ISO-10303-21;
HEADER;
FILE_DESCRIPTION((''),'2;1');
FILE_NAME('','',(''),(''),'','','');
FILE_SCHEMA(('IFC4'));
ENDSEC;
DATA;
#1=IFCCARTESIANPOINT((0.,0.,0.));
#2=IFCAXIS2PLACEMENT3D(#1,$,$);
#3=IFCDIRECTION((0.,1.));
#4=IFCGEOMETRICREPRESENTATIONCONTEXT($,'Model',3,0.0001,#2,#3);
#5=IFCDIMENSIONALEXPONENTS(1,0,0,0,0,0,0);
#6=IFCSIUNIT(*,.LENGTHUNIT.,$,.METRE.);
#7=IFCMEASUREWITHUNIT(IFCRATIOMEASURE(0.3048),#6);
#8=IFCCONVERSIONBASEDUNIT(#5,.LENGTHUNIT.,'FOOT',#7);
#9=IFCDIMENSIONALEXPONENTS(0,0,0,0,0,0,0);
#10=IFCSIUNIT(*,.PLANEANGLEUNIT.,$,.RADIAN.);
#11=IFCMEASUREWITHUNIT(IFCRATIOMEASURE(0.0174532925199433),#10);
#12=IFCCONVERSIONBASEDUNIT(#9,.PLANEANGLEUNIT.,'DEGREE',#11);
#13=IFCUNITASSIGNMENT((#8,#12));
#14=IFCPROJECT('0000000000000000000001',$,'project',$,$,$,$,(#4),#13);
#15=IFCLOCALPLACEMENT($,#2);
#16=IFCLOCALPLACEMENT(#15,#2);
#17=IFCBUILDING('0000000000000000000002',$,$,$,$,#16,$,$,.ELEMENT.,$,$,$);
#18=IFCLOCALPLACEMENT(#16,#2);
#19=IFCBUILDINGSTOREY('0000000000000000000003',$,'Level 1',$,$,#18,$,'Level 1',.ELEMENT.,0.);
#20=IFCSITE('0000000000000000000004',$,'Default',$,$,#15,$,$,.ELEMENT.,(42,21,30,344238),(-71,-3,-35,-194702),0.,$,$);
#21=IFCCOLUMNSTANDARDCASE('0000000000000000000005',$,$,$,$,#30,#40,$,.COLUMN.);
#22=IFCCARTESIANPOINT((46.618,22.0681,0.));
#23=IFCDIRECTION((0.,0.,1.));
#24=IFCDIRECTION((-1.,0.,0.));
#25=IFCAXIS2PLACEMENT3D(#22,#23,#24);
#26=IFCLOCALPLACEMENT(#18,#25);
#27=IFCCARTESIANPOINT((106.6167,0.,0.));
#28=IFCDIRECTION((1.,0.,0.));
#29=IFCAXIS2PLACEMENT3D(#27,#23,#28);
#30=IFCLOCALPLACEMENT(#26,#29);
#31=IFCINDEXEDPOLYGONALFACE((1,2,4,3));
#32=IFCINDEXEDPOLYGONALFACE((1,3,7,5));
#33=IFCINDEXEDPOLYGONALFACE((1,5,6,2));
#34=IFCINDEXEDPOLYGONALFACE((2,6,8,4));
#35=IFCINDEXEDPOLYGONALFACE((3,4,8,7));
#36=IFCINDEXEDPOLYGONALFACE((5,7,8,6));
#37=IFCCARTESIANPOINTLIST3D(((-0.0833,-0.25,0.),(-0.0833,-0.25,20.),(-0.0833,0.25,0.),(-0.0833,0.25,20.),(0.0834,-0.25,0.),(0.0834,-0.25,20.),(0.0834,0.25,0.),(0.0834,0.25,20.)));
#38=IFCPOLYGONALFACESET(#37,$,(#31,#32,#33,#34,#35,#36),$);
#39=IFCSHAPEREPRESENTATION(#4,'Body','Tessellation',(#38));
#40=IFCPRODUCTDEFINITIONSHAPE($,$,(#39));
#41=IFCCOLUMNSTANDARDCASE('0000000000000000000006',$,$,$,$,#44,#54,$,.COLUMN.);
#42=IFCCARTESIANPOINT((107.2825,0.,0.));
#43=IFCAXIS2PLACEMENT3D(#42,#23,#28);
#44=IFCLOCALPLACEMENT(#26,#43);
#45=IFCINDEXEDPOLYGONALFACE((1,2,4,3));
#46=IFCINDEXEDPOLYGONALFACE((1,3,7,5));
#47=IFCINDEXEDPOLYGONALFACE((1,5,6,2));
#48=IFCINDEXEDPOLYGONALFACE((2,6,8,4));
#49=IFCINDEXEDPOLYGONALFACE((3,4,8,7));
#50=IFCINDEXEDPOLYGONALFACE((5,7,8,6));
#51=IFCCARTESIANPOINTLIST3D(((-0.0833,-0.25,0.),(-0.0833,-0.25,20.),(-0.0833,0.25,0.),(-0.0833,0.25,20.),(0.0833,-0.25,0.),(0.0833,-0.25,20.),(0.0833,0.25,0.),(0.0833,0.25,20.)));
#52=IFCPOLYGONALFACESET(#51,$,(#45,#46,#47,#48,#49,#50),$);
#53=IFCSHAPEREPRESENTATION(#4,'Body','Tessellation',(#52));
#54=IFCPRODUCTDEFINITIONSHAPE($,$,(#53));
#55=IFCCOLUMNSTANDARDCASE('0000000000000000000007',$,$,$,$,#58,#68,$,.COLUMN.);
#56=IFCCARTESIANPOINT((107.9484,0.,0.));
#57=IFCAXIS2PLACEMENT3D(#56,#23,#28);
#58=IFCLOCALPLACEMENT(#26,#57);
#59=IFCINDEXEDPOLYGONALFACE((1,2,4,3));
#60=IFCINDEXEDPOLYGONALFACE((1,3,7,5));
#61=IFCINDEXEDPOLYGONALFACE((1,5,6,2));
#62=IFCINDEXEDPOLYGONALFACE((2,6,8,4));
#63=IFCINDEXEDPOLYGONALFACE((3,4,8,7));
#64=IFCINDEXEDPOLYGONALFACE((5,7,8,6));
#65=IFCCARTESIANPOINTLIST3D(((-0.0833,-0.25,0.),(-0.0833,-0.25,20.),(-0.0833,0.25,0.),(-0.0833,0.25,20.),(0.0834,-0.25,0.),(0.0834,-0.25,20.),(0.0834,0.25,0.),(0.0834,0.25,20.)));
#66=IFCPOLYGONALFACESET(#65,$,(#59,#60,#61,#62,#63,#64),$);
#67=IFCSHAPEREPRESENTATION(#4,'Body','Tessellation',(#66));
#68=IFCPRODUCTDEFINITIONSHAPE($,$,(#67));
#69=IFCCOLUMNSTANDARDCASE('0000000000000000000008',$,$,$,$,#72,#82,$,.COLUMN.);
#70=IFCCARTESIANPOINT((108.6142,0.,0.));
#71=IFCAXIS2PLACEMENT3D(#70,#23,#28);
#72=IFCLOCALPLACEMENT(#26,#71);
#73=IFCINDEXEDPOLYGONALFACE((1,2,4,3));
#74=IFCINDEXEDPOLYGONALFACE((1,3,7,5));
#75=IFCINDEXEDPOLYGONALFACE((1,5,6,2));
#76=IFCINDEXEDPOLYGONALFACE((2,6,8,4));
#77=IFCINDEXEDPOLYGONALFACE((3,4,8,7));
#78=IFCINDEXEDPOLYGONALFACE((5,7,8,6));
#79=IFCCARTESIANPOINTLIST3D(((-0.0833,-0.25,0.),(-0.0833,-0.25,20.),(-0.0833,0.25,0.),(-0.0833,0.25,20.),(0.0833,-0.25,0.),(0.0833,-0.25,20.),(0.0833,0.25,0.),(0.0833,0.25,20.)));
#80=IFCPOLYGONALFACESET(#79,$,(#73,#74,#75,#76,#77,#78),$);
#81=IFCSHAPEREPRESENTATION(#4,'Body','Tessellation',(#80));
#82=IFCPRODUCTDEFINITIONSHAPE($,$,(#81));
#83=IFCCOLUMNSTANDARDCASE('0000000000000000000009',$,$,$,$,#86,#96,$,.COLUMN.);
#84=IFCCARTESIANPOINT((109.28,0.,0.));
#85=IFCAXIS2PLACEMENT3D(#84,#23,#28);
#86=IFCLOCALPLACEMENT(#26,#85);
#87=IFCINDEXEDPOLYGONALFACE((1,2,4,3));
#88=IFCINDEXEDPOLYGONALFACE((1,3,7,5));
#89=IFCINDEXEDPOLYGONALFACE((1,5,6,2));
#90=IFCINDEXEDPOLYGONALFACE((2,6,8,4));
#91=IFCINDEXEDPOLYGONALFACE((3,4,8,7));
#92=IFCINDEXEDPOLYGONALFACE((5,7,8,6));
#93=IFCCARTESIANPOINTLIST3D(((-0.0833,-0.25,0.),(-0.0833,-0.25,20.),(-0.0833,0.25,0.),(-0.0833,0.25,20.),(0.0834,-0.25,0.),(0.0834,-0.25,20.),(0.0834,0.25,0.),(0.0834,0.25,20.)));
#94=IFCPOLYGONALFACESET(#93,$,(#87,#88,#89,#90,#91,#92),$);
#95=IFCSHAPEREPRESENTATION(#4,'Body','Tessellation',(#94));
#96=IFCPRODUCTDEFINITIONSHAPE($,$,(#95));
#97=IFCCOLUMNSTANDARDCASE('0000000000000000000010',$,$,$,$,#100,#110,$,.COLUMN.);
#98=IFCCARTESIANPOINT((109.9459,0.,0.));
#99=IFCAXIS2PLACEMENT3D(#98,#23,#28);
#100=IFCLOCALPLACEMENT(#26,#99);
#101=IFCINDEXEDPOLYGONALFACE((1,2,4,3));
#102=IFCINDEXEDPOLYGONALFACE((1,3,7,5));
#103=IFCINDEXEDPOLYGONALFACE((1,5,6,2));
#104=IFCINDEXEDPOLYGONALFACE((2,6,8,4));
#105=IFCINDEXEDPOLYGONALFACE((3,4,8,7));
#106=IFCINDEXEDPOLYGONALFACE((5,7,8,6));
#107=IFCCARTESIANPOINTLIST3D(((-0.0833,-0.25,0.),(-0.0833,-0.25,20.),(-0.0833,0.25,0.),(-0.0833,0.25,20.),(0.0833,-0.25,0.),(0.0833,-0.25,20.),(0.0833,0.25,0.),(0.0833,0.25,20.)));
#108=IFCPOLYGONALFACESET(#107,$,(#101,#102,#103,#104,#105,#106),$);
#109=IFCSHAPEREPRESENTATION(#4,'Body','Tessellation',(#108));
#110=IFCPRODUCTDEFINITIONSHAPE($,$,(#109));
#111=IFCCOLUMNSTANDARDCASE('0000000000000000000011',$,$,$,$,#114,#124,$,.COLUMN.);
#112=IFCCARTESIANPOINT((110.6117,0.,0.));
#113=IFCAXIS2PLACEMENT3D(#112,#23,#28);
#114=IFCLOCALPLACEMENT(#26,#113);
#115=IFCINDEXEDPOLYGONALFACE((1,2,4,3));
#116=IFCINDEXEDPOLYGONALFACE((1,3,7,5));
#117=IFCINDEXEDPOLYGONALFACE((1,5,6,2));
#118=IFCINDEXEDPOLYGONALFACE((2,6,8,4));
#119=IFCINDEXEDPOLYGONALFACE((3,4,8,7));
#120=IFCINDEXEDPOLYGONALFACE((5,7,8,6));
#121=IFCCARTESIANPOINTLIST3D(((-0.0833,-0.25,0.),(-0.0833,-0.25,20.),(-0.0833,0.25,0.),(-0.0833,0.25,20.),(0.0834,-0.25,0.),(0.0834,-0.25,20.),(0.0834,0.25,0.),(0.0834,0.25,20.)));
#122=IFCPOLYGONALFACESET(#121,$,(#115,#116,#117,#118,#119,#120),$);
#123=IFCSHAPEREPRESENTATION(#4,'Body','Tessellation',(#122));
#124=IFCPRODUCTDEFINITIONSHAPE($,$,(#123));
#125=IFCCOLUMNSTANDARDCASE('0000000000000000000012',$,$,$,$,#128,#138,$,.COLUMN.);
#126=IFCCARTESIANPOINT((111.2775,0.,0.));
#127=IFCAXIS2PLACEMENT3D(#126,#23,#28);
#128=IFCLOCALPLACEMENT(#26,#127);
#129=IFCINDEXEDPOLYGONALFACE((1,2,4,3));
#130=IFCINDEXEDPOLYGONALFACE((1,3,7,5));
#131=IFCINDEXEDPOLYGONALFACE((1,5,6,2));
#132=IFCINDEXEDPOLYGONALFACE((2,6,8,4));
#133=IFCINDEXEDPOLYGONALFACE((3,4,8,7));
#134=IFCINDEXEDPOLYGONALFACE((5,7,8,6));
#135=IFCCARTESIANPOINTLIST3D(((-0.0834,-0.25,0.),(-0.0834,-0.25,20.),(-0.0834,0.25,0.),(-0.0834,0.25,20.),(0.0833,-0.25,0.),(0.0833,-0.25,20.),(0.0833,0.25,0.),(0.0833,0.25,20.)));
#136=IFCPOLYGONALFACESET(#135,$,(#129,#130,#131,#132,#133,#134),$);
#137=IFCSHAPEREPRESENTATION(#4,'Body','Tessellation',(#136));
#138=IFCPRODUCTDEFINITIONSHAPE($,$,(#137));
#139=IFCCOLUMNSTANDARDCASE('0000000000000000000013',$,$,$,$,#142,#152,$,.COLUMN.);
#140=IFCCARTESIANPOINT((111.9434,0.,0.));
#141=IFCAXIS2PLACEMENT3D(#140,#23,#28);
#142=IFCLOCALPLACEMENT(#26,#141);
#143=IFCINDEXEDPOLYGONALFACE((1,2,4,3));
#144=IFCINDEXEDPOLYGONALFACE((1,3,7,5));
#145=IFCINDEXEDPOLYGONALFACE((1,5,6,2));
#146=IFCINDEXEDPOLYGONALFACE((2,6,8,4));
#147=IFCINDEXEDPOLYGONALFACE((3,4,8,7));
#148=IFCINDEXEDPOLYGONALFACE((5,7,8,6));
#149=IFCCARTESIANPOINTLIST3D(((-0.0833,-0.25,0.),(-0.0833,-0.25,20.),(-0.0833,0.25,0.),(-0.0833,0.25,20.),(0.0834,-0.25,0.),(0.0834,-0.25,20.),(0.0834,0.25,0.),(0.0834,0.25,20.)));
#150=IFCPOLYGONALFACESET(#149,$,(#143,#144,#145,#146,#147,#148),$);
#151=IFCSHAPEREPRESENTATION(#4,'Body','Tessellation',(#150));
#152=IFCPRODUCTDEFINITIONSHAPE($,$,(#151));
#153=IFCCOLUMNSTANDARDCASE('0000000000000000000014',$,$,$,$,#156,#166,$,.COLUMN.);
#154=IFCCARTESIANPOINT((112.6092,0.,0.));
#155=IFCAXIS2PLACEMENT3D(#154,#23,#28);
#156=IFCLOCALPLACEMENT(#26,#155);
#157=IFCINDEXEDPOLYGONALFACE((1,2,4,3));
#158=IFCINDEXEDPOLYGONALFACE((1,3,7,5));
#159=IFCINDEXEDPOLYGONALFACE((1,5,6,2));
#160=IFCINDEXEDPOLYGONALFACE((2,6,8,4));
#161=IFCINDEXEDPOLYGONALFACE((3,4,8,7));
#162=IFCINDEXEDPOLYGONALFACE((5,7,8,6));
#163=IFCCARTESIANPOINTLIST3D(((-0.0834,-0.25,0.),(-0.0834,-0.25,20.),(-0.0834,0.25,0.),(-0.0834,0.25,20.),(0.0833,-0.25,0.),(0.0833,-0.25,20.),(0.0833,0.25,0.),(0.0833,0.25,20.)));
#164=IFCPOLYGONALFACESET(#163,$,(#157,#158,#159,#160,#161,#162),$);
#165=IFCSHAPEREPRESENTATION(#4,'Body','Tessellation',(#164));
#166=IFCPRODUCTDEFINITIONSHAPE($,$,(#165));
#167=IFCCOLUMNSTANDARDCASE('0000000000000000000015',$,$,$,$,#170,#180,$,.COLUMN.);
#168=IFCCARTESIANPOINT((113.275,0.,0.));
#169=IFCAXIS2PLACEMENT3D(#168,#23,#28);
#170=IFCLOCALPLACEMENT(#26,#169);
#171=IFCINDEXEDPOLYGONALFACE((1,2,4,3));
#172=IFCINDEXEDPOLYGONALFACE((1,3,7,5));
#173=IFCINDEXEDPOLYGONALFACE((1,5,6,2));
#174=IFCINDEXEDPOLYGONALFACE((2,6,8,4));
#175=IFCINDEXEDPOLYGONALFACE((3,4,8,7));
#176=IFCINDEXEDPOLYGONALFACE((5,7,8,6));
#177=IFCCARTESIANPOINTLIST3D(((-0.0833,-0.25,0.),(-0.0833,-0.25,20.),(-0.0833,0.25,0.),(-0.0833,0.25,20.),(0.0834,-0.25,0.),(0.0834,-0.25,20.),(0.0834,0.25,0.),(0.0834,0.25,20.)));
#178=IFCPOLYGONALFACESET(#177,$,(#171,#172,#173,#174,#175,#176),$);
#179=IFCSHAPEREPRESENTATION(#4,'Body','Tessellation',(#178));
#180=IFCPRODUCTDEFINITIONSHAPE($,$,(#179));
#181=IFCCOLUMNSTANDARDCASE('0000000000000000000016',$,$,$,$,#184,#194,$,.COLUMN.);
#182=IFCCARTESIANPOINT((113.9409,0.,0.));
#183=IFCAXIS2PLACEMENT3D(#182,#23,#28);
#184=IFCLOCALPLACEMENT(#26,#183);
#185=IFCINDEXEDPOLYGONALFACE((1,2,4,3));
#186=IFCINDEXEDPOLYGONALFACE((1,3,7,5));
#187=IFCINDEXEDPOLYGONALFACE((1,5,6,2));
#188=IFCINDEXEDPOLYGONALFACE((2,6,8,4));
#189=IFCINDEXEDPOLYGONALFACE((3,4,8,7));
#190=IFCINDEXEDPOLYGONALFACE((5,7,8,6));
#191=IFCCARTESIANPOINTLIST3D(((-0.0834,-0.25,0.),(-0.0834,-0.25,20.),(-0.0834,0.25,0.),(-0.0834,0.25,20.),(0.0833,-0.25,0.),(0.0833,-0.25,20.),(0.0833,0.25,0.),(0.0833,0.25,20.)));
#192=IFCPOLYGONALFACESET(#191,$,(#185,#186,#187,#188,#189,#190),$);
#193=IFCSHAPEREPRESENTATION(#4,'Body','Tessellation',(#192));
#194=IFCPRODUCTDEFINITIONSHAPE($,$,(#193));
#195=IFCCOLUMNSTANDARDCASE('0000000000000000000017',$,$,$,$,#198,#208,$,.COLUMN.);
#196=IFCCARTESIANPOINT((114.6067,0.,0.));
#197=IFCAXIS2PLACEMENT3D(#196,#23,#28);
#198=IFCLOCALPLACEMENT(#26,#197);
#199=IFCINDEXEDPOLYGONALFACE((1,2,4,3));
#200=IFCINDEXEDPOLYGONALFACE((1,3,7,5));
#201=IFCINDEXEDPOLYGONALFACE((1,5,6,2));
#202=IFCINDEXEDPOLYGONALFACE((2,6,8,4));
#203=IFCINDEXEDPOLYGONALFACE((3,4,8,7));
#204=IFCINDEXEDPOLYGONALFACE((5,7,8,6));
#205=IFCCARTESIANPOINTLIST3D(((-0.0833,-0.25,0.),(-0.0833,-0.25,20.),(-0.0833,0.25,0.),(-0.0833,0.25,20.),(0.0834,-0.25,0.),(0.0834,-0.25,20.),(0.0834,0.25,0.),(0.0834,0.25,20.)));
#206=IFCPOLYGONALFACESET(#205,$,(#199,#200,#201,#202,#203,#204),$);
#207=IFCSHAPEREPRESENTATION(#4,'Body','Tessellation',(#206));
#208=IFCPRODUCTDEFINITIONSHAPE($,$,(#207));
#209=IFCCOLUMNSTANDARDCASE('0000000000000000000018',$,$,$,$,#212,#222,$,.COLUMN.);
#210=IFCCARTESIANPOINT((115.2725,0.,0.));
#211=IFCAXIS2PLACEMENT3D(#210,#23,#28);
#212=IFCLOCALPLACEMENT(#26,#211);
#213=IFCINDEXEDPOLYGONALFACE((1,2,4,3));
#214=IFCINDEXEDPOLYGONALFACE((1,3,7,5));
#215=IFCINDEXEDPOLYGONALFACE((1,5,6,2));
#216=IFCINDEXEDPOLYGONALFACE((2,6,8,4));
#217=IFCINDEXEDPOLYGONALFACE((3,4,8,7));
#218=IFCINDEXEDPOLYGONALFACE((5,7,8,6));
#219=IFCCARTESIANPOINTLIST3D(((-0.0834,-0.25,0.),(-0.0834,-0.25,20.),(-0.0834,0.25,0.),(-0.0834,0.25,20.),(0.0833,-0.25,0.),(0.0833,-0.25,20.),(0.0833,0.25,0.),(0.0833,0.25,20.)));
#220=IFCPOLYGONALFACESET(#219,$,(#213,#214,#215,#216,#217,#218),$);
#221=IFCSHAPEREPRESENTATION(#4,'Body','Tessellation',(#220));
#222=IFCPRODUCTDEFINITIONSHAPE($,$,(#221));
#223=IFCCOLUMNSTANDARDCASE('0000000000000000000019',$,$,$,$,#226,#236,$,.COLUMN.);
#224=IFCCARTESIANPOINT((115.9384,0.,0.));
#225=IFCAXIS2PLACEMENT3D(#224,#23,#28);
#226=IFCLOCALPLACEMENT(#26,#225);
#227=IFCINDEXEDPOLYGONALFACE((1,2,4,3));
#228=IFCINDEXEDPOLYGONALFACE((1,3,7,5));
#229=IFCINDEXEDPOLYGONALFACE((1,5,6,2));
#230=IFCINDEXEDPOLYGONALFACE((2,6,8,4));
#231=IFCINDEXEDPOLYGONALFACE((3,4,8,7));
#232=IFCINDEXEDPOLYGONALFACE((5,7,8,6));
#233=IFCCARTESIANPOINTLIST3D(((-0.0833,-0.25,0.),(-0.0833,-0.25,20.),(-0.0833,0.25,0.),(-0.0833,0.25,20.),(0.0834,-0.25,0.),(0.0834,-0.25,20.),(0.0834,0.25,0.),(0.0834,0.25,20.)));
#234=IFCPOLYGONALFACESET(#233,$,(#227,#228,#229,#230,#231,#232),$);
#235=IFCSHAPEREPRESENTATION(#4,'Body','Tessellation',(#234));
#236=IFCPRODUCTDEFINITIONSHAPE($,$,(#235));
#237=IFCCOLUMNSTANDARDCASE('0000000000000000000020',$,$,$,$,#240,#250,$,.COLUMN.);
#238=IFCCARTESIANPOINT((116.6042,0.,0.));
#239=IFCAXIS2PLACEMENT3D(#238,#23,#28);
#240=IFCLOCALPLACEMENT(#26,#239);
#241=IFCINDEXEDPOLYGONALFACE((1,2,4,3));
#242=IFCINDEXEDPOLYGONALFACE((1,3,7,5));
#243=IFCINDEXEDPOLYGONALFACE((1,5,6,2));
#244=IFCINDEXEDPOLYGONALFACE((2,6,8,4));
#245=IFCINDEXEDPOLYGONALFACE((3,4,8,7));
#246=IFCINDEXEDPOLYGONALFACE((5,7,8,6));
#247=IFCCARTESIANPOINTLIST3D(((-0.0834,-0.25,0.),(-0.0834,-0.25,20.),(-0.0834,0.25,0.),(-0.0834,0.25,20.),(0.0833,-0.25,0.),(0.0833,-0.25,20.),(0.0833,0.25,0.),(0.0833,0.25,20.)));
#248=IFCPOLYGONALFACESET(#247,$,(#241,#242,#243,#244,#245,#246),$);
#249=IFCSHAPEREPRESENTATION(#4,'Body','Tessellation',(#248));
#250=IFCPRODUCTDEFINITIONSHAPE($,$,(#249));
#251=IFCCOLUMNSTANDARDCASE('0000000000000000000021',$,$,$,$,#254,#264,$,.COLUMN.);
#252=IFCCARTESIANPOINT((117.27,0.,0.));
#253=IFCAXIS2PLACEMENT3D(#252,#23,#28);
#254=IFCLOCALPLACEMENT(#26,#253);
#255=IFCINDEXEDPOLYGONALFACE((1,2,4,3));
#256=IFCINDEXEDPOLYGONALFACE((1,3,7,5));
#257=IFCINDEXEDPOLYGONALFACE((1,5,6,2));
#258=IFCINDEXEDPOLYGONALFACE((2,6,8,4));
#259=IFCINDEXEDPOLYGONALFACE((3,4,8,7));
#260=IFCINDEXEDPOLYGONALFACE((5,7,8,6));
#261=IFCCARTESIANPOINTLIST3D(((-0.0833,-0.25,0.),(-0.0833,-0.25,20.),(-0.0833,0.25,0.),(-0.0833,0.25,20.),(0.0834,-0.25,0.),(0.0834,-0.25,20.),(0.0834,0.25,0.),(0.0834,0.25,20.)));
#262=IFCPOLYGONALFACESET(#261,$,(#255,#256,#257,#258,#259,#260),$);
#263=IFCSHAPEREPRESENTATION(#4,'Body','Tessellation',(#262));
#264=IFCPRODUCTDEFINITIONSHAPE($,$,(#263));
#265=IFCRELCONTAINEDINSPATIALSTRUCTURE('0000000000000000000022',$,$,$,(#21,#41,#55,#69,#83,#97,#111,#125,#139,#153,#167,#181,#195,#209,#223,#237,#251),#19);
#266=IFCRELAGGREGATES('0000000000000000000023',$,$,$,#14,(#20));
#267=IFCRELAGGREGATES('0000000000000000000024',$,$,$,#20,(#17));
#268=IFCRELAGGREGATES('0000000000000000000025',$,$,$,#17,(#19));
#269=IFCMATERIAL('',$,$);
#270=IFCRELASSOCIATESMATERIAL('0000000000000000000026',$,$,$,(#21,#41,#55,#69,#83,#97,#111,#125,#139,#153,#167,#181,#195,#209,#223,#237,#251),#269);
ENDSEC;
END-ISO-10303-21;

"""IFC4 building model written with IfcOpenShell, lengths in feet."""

from ifc_helpers import new_model, entity, si_unit, converted_unit, direction, frame, origin, place, context, project, spatial, rectangle, extrude, material, element, save


model = new_model("IFC4")

# Units and contexts
model_context = context("Model", 3, precision=0.0001, world=origin(), true_north=direction((0.0, 1.0)))
ifc_project = project(units=[converted_unit("LENGTHUNIT", "FOOT", entity("IfcRatioMeasure", 0.3048), si_unit("LENGTHUNIT", "METRE"), dimensions=[1, 0, 0, 0, 0, 0, 0]), converted_unit("PLANEANGLEUNIT", "DEGREE", entity("IfcRatioMeasure", 0.0174532925199433), si_unit("PLANEANGLEUNIT", "RADIAN"), dimensions=[0, 0, 0, 0, 0, 0, 0])], contexts=[model_context])

# Site, building, storey
site_placement = place(None, origin())
site = spatial("IfcSite", under=ifc_project, at=site_placement, Name="Default", CompositionType="ELEMENT", RefLatitude=(42, 21, 30, 344238), RefLongitude=(-71, -3, -35, -194702), RefElevation=0.0)
building_placement = place(site_placement, origin())
building = spatial("IfcBuilding", under=site, at=building_placement, CompositionType="ELEMENT")
storey_placement = place(building_placement, origin())
storey = spatial("IfcBuildingStorey", under=building, at=storey_placement, Name="Level 1", LongName="Level 1", CompositionType="ELEMENT", Elevation=0.0)

# Columns
ifc_material_1 = material(Name="")
placement_1 = place(storey_placement, frame((46.618, 22.0681, 0.0), z_axis=(0.0, 0.0, 1.0), x_axis=(-1.0, 0.0, 0.0)))
for number, where, z_axis, x_axis in (
    (1, (106.6167, 0.0, 0.0), (0.0, 0.0, 1.0), (1.0, 0.0, 0.0)),
    (2, (107.2825, 0.0, 0.0), (0.0, 0.0, 1.0), (1.0, 0.0, 0.0)),
    (3, (107.9484, 0.0, 0.0), (0.0, 0.0, 1.0), (1.0, 0.0, 0.0)),
    (4, (108.6142, 0.0, 0.0), (0.0, 0.0, 1.0), (1.0, 0.0, 0.0)),
    (5, (109.28, 0.0, 0.0), (0.0, 0.0, 1.0), (1.0, 0.0, 0.0)),
    (6, (109.9459, 0.0, 0.0), (0.0, 0.0, 1.0), (1.0, 0.0, 0.0)),
    (7, (110.6117, 0.0, 0.0), (0.0, 0.0, 1.0), (1.0, 0.0, 0.0)),
    (8, (111.2775, 0.0, 0.0), (0.0, 0.0, 1.0), (1.0, 0.0, 0.0)),
    (9, (111.9434, 0.0, 0.0), (0.0, 0.0, 1.0), (1.0, 0.0, 0.0)),
    (10, (112.6092, 0.0, 0.0), (0.0, 0.0, 1.0), (1.0, 0.0, 0.0)),
    (11, (113.275, 0.0, 0.0), (0.0, 0.0, 1.0), (1.0, 0.0, 0.0)),
    (12, (113.9409, 0.0, 0.0), (0.0, 0.0, 1.0), (1.0, 0.0, 0.0)),
    (13, (114.6067, 0.0, 0.0), (0.0, 0.0, 1.0), (1.0, 0.0, 0.0)),
    (14, (115.2725, 0.0, 0.0), (0.0, 0.0, 1.0), (1.0, 0.0, 0.0)),
    (15, (115.9384, 0.0, 0.0), (0.0, 0.0, 1.0), (1.0, 0.0, 0.0)),
    (16, (116.6042, 0.0, 0.0), (0.0, 0.0, 1.0), (1.0, 0.0, 0.0)),
    (17, (117.27, 0.0, 0.0), (0.0, 0.0, 1.0), (1.0, 0.0, 0.0)),
):
    element("IfcColumnStandardCase", number, at=place(placement_1, frame(where, z_axis=z_axis, x_axis=x_axis)), inside=storey, material=ifc_material_1, PredefinedType="COLUMN", context=model_context, shape_type="SweptSolid", body=[
        extrude(rectangle(XDim=0.1667, YDim=0.5), origin(), (0.0, 0.0, 1.0), 20.0),
    ])

save(model, "model.ifc")
